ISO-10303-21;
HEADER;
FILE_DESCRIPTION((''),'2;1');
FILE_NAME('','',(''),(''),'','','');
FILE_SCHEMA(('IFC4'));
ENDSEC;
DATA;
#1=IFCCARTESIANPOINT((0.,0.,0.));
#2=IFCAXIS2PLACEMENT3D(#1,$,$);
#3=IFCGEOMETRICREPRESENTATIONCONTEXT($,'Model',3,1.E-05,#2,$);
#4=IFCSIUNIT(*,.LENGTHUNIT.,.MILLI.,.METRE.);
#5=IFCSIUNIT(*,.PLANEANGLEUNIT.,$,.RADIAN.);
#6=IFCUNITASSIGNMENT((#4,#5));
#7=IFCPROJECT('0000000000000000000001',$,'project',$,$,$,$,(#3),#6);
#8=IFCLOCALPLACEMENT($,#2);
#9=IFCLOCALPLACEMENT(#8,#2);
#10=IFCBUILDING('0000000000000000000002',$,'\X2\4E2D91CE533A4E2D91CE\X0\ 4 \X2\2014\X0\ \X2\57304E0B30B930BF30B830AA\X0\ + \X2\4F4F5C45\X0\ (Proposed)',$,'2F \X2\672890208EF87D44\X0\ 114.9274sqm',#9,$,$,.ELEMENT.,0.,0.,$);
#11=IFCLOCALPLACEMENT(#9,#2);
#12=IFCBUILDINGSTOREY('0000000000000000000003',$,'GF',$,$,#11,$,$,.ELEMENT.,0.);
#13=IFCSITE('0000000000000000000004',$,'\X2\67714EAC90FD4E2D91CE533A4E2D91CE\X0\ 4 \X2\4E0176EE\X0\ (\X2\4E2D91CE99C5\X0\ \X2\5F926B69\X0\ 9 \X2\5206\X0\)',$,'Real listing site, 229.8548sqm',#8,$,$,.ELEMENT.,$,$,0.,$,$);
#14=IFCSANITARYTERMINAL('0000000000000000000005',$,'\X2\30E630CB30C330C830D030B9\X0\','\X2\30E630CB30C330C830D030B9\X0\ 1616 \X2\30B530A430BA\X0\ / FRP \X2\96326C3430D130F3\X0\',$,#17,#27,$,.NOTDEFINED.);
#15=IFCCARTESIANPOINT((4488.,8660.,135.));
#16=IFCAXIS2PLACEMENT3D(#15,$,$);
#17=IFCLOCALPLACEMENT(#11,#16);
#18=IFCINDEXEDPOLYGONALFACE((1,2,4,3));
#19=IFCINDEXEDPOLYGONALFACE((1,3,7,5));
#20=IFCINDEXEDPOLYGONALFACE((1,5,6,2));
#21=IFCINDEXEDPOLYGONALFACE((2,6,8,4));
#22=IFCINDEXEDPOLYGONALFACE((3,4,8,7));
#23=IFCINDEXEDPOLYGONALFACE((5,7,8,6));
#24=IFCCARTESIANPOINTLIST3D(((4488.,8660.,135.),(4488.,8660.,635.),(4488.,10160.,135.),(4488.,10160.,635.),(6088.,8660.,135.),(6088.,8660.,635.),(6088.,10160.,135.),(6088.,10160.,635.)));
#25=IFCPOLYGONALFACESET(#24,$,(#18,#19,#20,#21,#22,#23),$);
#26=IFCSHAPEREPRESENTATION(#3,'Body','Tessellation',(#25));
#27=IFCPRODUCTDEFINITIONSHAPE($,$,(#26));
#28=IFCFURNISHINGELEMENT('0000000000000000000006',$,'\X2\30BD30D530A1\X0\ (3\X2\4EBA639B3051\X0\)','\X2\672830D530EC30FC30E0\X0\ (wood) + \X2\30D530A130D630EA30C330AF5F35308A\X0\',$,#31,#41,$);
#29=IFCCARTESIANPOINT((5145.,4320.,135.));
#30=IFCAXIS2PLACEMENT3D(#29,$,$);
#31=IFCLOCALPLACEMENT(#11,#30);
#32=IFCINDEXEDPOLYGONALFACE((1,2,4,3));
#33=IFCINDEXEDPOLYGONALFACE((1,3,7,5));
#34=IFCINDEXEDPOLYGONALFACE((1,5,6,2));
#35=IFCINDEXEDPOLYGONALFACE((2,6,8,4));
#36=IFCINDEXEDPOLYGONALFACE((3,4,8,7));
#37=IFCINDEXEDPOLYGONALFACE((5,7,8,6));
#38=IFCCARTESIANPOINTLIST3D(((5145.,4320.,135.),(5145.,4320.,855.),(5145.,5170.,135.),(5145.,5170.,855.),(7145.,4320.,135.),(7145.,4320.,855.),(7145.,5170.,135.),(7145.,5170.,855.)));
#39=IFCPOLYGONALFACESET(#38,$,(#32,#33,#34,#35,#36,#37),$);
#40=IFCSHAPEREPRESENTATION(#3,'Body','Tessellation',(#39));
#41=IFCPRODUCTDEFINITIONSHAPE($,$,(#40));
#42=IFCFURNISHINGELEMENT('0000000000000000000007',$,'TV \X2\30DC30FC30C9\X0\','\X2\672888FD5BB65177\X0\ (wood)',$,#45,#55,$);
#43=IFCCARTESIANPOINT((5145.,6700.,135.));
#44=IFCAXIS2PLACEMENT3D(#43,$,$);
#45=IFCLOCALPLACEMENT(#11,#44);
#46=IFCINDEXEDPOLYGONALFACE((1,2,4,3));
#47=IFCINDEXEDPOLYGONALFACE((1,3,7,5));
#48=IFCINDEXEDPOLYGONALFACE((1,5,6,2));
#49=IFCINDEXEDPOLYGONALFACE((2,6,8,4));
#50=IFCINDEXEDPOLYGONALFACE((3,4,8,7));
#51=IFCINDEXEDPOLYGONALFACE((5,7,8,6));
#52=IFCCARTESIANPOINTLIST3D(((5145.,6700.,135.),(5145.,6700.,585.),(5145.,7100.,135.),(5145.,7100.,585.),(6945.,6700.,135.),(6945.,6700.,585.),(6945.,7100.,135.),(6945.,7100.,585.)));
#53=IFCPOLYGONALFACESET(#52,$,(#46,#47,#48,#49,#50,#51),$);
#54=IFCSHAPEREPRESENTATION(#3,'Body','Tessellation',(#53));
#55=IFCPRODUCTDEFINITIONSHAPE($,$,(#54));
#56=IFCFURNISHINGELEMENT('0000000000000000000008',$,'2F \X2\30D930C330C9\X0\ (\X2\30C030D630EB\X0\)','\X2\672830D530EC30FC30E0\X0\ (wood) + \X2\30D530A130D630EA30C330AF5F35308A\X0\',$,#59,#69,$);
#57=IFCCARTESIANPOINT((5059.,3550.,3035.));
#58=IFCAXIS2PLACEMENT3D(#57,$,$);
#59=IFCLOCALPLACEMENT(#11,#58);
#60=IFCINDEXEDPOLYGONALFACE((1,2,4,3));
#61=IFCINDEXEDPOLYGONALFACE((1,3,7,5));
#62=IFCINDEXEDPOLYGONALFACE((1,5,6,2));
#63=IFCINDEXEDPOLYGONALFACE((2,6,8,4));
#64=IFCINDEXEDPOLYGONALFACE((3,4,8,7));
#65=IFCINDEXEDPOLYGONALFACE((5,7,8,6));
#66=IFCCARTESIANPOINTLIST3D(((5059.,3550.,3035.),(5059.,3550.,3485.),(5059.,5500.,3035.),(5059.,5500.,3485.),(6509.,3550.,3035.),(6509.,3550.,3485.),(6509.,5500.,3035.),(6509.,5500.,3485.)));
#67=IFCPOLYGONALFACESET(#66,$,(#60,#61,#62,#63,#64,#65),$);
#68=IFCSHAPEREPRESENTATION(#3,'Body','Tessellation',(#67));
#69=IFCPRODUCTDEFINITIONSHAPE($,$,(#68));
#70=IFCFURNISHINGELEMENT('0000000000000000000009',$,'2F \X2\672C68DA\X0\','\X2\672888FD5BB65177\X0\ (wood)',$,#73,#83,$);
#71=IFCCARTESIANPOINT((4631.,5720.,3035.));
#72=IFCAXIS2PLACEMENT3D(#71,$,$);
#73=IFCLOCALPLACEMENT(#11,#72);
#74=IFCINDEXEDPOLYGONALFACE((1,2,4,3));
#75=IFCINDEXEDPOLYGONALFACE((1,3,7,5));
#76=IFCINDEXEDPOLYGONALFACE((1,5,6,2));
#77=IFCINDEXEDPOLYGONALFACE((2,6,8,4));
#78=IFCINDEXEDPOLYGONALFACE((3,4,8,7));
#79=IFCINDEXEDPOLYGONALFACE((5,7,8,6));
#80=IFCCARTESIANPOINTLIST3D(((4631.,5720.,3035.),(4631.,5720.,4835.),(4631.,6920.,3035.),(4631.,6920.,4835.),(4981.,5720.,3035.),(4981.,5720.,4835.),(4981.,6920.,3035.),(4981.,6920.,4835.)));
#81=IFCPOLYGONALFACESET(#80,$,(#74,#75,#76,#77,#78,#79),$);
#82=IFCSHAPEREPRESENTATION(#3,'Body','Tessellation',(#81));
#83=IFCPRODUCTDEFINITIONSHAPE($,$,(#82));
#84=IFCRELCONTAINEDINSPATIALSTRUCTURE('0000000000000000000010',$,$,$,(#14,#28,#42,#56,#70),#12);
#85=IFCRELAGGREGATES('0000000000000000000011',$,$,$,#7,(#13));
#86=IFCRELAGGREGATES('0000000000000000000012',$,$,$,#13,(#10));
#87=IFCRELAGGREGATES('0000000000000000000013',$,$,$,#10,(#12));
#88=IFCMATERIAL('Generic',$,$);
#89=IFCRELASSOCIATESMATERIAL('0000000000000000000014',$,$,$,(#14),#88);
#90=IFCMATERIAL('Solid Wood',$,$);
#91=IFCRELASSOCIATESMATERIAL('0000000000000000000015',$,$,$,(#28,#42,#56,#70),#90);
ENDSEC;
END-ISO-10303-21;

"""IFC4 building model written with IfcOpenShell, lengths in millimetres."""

from ifc_helpers import new_model, si_unit, frame, frame_2d, origin, place, context, project, spatial, rectangle, extrude, material, element, save


model = new_model("IFC4")

# Units and contexts
model_context = context("Model", 3, precision=1e-05, world=origin())
ifc_project = project(units=[si_unit("LENGTHUNIT", "METRE", prefix="MILLI"), si_unit("PLANEANGLEUNIT", "RADIAN")], contexts=[model_context])

# Site, building, storey
site_placement = place(None, origin())
site = spatial("IfcSite", under=ifc_project, at=site_placement, Name="東京都中野区中野 4 丁目 (中野駅 徒歩 9 分)", ObjectType="Real listing site, 229.8548sqm", CompositionType="ELEMENT", RefElevation=0.0)
building_placement = place(site_placement, origin())
building = spatial("IfcBuilding", under=site, at=building_placement, Name="中野区中野 4 — 地下スタジオ + 住居 (Proposed)", ObjectType="2F 木造軸組 114.9274sqm", CompositionType="ELEMENT", ElevationOfRefHeight=0.0, ElevationOfTerrain=0.0)
storey_placement = place(building_placement, origin())
storey = spatial("IfcBuildingStorey", under=building, at=storey_placement, Name="GF", CompositionType="ELEMENT", Elevation=0.0)

# Shared definitions
ifc_material_1 = material(Name="Solid Wood")

# Sanitary terminal
ifc_material_2 = material(Name="Generic")
sanitary_terminal_placement = place(storey_placement, frame((4488.0, 8660.0, 135.0)))
element("IfcSanitaryTerminal", 1, at=sanitary_terminal_placement, inside=storey, material=ifc_material_2, Name="ユニットバス", Description="ユニットバス 1616 サイズ / FRP 防水パン", PredefinedType="NOTDEFINED", context=model_context, shape_type="SweptSolid", body=[
    extrude(rectangle(XDim=1600.0, YDim=1500.0, at=frame_2d((800.0, 750.0))), frame((4488.0, 8660.0, 135.0)), (0.0, 0.0, 1.0), 500.0),
])

# Furnishing elements
furnishing_1_placement = place(storey_placement, frame((5145.0, 4320.0, 135.0)))
element("IfcFurnishingElement", 2, at=furnishing_1_placement, inside=storey, material=ifc_material_1, Name="ソファ (3人掛け)", Description="木フレーム (wood) + ファブリック張り", context=model_context, shape_type="SweptSolid", body=[
    extrude(rectangle(XDim=2000.0, YDim=850.0, at=frame_2d((1000.0, 425.0))), frame((5145.0, 4320.0, 135.0)), (0.0, 0.0, 1.0), 720.0),
])
furnishing_2_placement = place(storey_placement, frame((5145.0, 6700.0, 135.0)))
element("IfcFurnishingElement", 3, at=furnishing_2_placement, inside=storey, material=ifc_material_1, Name="TV ボード", Description="木製家具 (wood)", context=model_context, shape_type="SweptSolid", body=[
    extrude(rectangle(XDim=1800.0, YDim=400.0, at=frame_2d((900.0, 200.0))), frame((5145.0, 6700.0, 135.0)), (0.0, 0.0, 1.0), 450.0),
])
furnishing_3_placement = place(storey_placement, frame((5059.0, 3550.0, 3035.0)))
element("IfcFurnishingElement", 4, at=furnishing_3_placement, inside=storey, material=ifc_material_1, Name="2F ベッド (ダブル)", Description="木フレーム (wood) + ファブリック張り", context=model_context, shape_type="SweptSolid", body=[
    extrude(rectangle(XDim=1450.0, YDim=1950.0, at=frame_2d((725.0, 975.0))), frame((5059.0, 3550.0, 3035.0)), (0.0, 0.0, 1.0), 450.0),
])
furnishing_4_placement = place(storey_placement, frame((4631.0, 5720.0, 3035.0)))
element("IfcFurnishingElement", 5, at=furnishing_4_placement, inside=storey, material=ifc_material_1, Name="2F 本棚", Description="木製家具 (wood)", context=model_context, shape_type="SweptSolid", body=[
    extrude(rectangle(XDim=350.0, YDim=1200.0, at=frame_2d((175.0, 600.0))), frame((4631.0, 5720.0, 3035.0)), (0.0, 0.0, 1.0), 1800.0),
])

save(model, "model.ifc")
